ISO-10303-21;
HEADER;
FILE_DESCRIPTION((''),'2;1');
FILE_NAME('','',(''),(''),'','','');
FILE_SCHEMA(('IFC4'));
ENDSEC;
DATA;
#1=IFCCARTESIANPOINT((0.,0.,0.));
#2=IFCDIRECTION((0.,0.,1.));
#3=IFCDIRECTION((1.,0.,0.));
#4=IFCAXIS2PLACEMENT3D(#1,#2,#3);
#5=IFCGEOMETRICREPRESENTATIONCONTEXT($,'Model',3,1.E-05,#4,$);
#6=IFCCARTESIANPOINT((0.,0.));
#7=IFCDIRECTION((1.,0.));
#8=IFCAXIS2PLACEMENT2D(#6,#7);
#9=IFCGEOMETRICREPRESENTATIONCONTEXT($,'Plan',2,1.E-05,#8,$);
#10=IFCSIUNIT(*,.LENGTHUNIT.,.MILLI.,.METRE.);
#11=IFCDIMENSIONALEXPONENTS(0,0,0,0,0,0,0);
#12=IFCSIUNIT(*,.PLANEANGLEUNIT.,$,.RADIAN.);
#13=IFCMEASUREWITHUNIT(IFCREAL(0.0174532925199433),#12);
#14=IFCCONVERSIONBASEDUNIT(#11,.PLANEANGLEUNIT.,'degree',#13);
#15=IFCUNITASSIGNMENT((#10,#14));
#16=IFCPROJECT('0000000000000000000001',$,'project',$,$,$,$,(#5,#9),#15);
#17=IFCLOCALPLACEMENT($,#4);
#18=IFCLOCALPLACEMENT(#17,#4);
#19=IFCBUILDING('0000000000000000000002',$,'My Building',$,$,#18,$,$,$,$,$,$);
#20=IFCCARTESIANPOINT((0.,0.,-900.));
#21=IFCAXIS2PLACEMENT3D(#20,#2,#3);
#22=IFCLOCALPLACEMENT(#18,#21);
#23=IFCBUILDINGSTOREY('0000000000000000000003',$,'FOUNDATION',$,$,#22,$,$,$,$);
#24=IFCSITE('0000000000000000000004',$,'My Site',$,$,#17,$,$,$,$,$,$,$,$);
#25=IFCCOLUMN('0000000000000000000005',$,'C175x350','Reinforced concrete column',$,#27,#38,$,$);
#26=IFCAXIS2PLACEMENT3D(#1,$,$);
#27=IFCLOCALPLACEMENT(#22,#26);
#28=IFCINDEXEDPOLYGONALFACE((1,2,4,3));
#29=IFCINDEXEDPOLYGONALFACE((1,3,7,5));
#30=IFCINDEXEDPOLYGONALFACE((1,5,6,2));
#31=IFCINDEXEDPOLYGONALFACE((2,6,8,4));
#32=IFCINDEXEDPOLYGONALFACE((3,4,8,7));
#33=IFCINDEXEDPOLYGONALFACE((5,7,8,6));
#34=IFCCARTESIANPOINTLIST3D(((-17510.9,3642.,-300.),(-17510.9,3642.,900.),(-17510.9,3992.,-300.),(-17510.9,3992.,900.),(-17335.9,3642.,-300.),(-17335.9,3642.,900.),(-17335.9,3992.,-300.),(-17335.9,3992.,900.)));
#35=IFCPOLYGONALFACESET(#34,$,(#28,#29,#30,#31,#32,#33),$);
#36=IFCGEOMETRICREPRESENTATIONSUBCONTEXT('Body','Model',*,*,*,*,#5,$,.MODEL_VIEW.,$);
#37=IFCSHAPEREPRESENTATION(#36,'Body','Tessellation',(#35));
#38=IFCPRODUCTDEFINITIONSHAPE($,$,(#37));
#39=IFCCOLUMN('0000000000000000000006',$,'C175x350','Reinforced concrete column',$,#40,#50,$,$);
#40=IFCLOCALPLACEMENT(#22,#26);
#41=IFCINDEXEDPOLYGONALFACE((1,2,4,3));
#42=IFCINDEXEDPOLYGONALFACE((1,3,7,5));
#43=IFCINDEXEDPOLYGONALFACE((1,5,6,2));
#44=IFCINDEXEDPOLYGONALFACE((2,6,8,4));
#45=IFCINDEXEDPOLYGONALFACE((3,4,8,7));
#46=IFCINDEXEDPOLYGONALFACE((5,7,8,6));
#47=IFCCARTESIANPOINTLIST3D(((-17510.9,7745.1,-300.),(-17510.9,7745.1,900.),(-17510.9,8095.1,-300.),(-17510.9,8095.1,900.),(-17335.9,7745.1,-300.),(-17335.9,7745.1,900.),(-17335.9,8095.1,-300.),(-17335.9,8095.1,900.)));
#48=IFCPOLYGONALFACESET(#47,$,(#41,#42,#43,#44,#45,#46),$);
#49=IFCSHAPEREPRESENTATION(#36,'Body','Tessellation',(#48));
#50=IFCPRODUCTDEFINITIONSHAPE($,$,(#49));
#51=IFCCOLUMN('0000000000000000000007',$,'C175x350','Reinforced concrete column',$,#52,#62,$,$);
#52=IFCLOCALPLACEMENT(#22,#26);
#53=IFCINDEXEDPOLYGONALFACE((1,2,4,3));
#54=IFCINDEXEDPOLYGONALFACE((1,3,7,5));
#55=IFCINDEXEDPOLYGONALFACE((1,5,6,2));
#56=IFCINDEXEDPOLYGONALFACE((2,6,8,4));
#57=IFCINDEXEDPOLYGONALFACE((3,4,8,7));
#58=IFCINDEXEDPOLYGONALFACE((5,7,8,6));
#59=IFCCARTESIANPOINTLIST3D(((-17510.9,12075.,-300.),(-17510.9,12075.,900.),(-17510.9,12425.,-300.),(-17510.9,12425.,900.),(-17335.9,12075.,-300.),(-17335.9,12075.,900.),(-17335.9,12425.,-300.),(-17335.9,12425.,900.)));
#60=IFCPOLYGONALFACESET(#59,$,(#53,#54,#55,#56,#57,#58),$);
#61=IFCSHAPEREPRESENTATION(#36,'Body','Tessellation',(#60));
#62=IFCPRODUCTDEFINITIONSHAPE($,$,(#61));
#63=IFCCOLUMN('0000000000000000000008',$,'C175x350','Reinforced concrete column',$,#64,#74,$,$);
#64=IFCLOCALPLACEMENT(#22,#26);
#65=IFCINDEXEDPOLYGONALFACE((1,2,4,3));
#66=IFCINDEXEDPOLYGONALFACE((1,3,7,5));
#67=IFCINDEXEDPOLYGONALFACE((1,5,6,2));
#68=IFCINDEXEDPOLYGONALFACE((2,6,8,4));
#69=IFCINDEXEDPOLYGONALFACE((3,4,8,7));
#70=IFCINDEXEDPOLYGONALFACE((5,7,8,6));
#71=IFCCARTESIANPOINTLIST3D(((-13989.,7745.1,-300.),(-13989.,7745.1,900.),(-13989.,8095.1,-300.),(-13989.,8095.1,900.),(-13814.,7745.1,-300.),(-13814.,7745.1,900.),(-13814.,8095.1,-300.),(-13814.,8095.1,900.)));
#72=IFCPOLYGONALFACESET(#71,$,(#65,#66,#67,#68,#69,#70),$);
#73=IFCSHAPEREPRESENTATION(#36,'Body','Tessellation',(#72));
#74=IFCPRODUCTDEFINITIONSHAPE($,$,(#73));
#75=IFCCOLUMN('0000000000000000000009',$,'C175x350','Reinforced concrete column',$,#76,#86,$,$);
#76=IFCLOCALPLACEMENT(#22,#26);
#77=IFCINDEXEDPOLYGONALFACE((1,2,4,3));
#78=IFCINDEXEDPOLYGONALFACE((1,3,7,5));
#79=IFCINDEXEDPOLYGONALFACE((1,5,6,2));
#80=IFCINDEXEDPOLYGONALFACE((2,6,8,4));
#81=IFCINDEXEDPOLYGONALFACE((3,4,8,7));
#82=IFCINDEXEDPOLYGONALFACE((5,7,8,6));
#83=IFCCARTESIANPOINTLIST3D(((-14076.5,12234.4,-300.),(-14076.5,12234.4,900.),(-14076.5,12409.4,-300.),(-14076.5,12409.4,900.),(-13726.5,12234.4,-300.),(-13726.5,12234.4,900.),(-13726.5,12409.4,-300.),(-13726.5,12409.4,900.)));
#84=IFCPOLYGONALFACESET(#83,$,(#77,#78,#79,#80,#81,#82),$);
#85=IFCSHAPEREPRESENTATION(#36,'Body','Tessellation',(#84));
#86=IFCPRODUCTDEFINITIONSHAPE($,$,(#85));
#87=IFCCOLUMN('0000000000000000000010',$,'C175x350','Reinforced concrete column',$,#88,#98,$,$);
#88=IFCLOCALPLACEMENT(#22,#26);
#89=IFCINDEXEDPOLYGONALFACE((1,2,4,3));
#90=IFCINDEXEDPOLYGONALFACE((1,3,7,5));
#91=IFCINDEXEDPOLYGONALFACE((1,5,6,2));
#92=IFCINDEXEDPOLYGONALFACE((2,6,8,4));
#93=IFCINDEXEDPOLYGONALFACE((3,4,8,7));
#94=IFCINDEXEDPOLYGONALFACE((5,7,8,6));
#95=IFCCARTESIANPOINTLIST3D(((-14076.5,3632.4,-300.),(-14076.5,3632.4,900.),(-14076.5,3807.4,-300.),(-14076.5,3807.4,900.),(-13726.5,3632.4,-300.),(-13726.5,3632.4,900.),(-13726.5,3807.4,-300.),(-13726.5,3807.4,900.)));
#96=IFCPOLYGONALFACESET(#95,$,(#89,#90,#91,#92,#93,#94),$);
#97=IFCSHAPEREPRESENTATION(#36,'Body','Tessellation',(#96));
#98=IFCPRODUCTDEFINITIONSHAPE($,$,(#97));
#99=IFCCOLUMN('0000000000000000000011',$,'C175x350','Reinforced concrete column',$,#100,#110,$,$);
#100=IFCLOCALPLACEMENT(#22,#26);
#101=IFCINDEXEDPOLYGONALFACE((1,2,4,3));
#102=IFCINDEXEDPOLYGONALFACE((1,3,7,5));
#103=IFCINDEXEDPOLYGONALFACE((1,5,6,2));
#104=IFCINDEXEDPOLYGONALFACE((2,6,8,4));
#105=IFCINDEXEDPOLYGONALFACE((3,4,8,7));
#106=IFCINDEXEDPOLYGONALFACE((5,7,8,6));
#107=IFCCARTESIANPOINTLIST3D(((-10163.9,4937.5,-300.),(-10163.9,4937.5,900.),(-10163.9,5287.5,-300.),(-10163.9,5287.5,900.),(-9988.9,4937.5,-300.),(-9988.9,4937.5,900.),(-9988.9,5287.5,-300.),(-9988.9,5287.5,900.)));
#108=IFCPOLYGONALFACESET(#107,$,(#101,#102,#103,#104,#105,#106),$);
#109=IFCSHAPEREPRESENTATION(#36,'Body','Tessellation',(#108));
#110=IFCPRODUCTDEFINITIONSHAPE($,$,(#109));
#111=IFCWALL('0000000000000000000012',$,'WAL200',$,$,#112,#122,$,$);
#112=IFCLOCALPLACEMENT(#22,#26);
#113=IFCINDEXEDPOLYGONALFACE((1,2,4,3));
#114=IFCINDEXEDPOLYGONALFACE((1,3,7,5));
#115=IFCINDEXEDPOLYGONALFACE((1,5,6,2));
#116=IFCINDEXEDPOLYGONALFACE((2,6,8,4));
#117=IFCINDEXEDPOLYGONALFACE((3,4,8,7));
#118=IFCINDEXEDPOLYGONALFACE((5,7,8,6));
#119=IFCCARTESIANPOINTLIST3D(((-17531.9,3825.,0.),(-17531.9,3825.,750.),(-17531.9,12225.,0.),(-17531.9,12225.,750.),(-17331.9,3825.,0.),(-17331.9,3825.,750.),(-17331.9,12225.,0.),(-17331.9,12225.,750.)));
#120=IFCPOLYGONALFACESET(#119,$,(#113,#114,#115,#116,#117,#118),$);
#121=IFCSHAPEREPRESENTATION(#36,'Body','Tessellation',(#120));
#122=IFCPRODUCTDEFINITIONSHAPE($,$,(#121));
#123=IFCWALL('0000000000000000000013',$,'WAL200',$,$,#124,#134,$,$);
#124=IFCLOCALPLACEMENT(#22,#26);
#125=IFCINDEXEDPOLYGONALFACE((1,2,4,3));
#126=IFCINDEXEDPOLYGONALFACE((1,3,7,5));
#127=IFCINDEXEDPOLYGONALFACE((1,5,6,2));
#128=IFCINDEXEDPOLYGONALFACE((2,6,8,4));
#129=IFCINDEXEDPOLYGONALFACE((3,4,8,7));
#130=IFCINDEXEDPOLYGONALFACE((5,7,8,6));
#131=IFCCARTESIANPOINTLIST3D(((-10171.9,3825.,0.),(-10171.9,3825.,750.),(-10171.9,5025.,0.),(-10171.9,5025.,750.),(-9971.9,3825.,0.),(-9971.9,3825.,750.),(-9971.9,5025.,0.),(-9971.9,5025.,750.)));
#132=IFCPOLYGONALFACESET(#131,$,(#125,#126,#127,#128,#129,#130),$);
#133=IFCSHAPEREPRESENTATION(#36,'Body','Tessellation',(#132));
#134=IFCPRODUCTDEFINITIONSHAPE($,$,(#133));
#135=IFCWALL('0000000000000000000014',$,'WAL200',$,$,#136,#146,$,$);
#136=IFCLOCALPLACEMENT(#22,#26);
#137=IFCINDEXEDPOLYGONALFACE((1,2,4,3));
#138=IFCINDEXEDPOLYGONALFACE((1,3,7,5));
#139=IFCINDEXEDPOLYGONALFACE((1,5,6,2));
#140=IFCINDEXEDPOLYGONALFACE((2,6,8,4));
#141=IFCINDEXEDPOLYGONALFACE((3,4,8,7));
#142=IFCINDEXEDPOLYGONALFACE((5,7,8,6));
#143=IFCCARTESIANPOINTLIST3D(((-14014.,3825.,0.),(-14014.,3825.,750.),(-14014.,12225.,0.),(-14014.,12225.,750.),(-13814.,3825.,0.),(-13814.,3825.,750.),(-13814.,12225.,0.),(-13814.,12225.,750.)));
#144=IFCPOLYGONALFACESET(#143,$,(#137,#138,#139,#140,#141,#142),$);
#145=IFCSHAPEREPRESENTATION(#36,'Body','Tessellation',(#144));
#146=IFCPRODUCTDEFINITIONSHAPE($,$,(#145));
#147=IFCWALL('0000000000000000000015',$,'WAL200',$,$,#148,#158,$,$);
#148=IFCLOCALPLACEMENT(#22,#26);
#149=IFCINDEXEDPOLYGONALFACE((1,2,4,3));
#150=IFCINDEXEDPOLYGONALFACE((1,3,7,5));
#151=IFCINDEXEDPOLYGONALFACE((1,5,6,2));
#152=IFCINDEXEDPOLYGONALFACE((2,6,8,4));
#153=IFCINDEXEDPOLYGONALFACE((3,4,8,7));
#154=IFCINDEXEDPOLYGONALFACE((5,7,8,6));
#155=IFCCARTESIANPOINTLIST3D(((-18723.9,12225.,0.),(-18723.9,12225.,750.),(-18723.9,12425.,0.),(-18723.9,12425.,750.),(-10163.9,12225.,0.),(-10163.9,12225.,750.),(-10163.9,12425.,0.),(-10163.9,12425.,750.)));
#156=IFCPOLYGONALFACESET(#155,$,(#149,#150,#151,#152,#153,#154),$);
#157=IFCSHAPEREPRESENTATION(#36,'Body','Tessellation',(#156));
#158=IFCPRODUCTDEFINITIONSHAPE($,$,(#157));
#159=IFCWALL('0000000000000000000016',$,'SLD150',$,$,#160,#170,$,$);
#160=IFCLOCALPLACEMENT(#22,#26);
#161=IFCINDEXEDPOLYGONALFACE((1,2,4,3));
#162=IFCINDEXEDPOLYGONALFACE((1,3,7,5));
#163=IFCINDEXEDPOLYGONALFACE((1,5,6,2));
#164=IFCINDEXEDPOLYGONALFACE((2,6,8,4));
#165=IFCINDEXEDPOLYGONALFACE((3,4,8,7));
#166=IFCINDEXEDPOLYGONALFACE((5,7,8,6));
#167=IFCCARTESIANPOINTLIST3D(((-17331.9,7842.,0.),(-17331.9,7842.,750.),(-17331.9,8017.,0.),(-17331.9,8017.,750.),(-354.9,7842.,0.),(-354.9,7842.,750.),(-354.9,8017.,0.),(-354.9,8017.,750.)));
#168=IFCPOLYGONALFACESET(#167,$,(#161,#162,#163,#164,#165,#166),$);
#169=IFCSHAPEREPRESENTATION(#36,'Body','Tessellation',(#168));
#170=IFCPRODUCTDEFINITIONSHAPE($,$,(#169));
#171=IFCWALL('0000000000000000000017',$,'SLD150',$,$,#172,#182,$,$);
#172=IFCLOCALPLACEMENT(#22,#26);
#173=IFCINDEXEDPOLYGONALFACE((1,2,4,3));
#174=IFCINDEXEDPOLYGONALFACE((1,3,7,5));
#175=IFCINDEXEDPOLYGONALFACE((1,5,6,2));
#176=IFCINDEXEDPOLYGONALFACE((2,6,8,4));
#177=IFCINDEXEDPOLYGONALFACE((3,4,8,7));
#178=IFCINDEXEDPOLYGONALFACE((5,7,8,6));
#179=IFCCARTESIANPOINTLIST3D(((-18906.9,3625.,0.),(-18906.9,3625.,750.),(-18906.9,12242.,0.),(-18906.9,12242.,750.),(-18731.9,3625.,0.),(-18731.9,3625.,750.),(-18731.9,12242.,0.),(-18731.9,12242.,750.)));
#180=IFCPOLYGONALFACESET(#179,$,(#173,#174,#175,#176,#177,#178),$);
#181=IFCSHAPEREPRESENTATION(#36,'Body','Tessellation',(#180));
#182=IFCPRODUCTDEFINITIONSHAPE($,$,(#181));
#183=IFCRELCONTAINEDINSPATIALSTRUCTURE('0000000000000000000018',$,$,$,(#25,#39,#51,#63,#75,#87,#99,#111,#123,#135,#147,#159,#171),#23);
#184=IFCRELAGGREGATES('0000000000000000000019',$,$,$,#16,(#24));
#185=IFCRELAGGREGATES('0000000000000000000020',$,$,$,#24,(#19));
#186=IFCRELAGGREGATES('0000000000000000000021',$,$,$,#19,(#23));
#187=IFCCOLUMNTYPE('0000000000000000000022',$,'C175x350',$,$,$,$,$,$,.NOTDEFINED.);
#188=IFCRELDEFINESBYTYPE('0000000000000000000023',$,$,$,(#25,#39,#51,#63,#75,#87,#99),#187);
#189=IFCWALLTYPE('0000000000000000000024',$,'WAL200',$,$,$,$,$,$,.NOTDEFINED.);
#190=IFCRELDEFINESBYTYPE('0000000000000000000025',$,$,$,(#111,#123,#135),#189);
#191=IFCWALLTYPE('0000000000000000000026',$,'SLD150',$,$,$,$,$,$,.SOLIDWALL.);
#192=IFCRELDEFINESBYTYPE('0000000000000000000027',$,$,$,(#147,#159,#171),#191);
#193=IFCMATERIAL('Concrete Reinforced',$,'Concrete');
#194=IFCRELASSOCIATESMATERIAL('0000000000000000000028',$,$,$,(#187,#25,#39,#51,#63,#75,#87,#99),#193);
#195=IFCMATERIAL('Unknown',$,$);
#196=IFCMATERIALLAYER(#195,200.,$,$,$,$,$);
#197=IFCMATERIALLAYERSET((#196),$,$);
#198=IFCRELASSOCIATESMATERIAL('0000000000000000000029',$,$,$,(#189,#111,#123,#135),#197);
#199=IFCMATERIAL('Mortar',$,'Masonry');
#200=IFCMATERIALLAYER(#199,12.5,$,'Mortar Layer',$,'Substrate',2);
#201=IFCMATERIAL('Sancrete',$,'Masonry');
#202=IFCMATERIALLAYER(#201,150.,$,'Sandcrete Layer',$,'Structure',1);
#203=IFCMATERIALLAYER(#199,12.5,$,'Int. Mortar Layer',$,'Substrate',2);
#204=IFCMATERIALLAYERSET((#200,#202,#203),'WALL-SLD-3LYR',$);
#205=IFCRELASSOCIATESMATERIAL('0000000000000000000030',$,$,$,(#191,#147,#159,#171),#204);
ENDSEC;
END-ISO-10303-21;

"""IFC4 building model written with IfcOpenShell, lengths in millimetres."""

from ifc_helpers import new_model, entity, si_unit, converted_unit, frame, origin_with_axes, origin_2d_with_axis, place, context, subcontext, project, spatial, indexed_curve, rectangle, outline, extrude, material, layer, layer_set, layer_usage, material_profile, profile_set, profile_usage, type_object, element, save


model = new_model("IFC4")

# Units and contexts
model_context = context("Model", 3, precision=1e-05, world=origin_with_axes())
plan_context = context("Plan", 2, precision=1e-05, world=origin_2d_with_axis())
body_context = subcontext(model_context, "Body", "Model", "MODEL_VIEW")
ifc_project = project(units=[si_unit("LENGTHUNIT", "METRE", prefix="MILLI"), converted_unit("PLANEANGLEUNIT", "degree", entity("IfcReal", 0.0174532925199433), si_unit("PLANEANGLEUNIT", "RADIAN"), dimensions=[0, 0, 0, 0, 0, 0, 0])], contexts=[model_context, plan_context])

# Site, building, storey
site_placement = place(None, origin_with_axes())
site = spatial("IfcSite", under=ifc_project, at=site_placement, Name="My Site")
building_placement = place(site_placement, origin_with_axes())
building = spatial("IfcBuilding", under=site, at=building_placement, Name="My Building")
storey_placement = place(building_placement, frame((0.0, 0.0, -900.0), z_axis=(0.0, 0.0, 1.0), x_axis=(1.0, 0.0, 0.0)))
storey = spatial("IfcBuildingStorey", under=building, at=storey_placement, Name="FOUNDATION")

# Shared definitions
ifc_material_1 = material(Name="Concrete Reinforced", Category="Concrete")

# Columns
ifc_material_profile = material_profile(ifc_material_1, rectangle(XDim=175.0, YDim=350.0), Name="R. C. Layer", Category="Structure", Priority=1)
ifc_profile_set = profile_set([ifc_material_profile], Name="COL_1LYR")
column_type = type_object("IfcColumnType", Name="C175x350", PredefinedType="NOTDEFINED", material=ifc_profile_set)
ifc_profile_usage_1 = profile_usage(ifc_profile_set, cardinal=5)
column_1_placement = place(storey_placement, frame((-17423.4, 3817.0, -300.0), z_axis=(0.0, 0.0, 1.0), x_axis=(1.0, 0.0, 0.0)))
element("IfcColumn", 1, at=column_1_placement, inside=storey, type_object=column_type, material=ifc_profile_usage_1, Name="C175x350", Description="Reinforced concrete column", context=body_context, shape_type="SweptSolid", body=[
    extrude(rectangle(XDim=175.0, YDim=350.0), origin_with_axes(), (0.0, 0.0, 1.0), 1200.0),
])
ifc_profile_usage_2 = profile_usage(ifc_profile_set, cardinal=5)
column_2_placement = place(storey_placement, frame((-17423.4, 7920.1, -300.0), z_axis=(0.0, 0.0, 1.0), x_axis=(1.0, 0.0, 0.0)))
element("IfcColumn", 2, at=column_2_placement, inside=storey, type_object=column_type, material=ifc_profile_usage_2, Name="C175x350", Description="Reinforced concrete column", context=body_context, shape_type="SweptSolid", body=[
    extrude(rectangle(XDim=175.0, YDim=350.0), origin_with_axes(), (0.0, 0.0, 1.0), 1200.0),
])
ifc_profile_usage_3 = profile_usage(ifc_profile_set, cardinal=5)
column_3_placement = place(storey_placement, frame((-17423.4, 12250.0, -300.0), z_axis=(0.0, 0.0, 1.0), x_axis=(1.0, 0.0, 0.0)))
element("IfcColumn", 3, at=column_3_placement, inside=storey, type_object=column_type, material=ifc_profile_usage_3, Name="C175x350", Description="Reinforced concrete column", context=body_context, shape_type="SweptSolid", body=[
    extrude(rectangle(XDim=175.0, YDim=350.0), origin_with_axes(), (0.0, 0.0, 1.0), 1200.0),
])
ifc_profile_usage_4 = profile_usage(ifc_profile_set, cardinal=5)
column_4_placement = place(storey_placement, frame((-13901.5, 7920.1, -300.0), z_axis=(0.0, 0.0, 1.0), x_axis=(1.0, 0.0, 0.0)))
element("IfcColumn", 4, at=column_4_placement, inside=storey, type_object=column_type, material=ifc_profile_usage_4, Name="C175x350", Description="Reinforced concrete column", context=body_context, shape_type="SweptSolid", body=[
    extrude(rectangle(XDim=175.0, YDim=350.0), origin_with_axes(), (0.0, 0.0, 1.0), 1200.0),
])
ifc_profile_usage_5 = profile_usage(ifc_profile_set, cardinal=5)
column_5_placement = place(storey_placement, frame((-13901.5, 12321.9, -300.0), z_axis=(0.0, 0.0, 1.0), x_axis=(0.0, -1.0, 0.0)))
element("IfcColumn", 5, at=column_5_placement, inside=storey, type_object=column_type, material=ifc_profile_usage_5, Name="C175x350", Description="Reinforced concrete column", context=body_context, shape_type="SweptSolid", body=[
    extrude(rectangle(XDim=175.0, YDim=350.0), origin_with_axes(), (0.0, 0.0, 1.0), 1200.0),
])
ifc_profile_usage_6 = profile_usage(ifc_profile_set, cardinal=5)
column_6_placement = place(storey_placement, frame((-13901.5, 3719.9, -300.0), z_axis=(0.0, 0.0, 1.0), x_axis=(0.0, -1.0, 0.0)))
element("IfcColumn", 6, at=column_6_placement, inside=storey, type_object=column_type, material=ifc_profile_usage_6, Name="C175x350", Description="Reinforced concrete column", context=body_context, shape_type="SweptSolid", body=[
    extrude(rectangle(XDim=175.0, YDim=350.0), origin_with_axes(), (0.0, 0.0, 1.0), 1200.0),
])
ifc_profile_usage_7 = profile_usage(ifc_profile_set, cardinal=5)
column_7_placement = place(storey_placement, frame((-10076.4, 5112.5, -300.0), z_axis=(0.0, 0.0, 1.0), x_axis=(1.0, 0.0, 0.0)))
element("IfcColumn", 7, at=column_7_placement, inside=storey, type_object=column_type, material=ifc_profile_usage_7, Name="C175x350", Description="Reinforced concrete column", context=body_context, shape_type="SweptSolid", body=[
    extrude(rectangle(XDim=175.0, YDim=350.0), origin_with_axes(), (0.0, 0.0, 1.0), 1200.0),
])

# Walls
ifc_material_2 = material(Name="Unknown")
ifc_layer_1 = layer(ifc_material_2, 200.0)
ifc_layer_set_1 = layer_set([ifc_layer_1])
ifc_layer_usage_1 = layer_usage(ifc_layer_set_1, "AXIS2", "POSITIVE", 0.0)
wall_type_1 = type_object("IfcWallType", Name="WAL200", PredefinedType="NOTDEFINED", material=ifc_layer_set_1)
wall_1_placement = place(storey_placement, frame((-17331.9, 3825.0, 0.0), z_axis=(0.0, 0.0, 1.0), x_axis=(0.0, 1.0, 0.0)))
element("IfcWall", 8, at=wall_1_placement, inside=storey, type_object=wall_type_1, material=ifc_layer_usage_1, Name="WAL200", context=body_context, shape_type="SweptSolid", body=[
    extrude(outline(indexed_curve([(0.0, 0.0), (0.0, 200.0), (8400.0, 200.0), (8400.0, 0.0), (0.0, 0.0)], self_intersect=False)), origin_with_axes(), (0.0, 0.0, 1.0), 750.0),
])
ifc_layer_usage_2 = layer_usage(ifc_layer_set_1, "AXIS2", "POSITIVE", 0.0)
wall_2_placement = place(storey_placement, frame((-10171.9, 5025.0, 0.0), z_axis=(0.0, 0.0, 1.0), x_axis=(-0.000001, -1.0, 0.0)))
element("IfcWall", 9, at=wall_2_placement, inside=storey, type_object=wall_type_1, material=ifc_layer_usage_2, Name="WAL200", context=body_context, shape_type="SweptSolid", body=[
    extrude(outline(indexed_curve([(0.0, 0.0), (0.0, 200.0), (1200.0, 200.0), (1200.0, 0.0), (0.0, 0.0)], self_intersect=False)), origin_with_axes(), (0.0, 0.0, 1.0), 750.0),
])
ifc_layer_usage_3 = layer_usage(ifc_layer_set_1, "AXIS2", "POSITIVE", 0.0)
wall_3_placement = place(storey_placement, frame((-13814.0, 3825.0, 0.0), z_axis=(0.0, 0.0, 1.0), x_axis=(0.0, 1.0, 0.0)))
element("IfcWall", 10, at=wall_3_placement, inside=storey, type_object=wall_type_1, material=ifc_layer_usage_3, Name="WAL200", context=body_context, shape_type="SweptSolid", body=[
    extrude(outline(indexed_curve([(0.0, 0.0), (0.0, 200.0), (8400.0, 200.0), (8400.0, 0.0), (0.0, 0.0)], self_intersect=False)), origin_with_axes(), (0.0, 0.0, 1.0), 750.0),
])
ifc_material_3 = material(Name="Mortar", Category="Masonry")
ifc_layer_2 = layer(ifc_material_3, 12.5, Name="Mortar Layer", Category="Substrate", Priority=2)
ifc_material_4 = material(Name="Sancrete", Category="Masonry")
ifc_layer_3 = layer(ifc_material_4, 150.0, Name="Sandcrete Layer", Category="Structure", Priority=1)
ifc_layer_4 = layer(ifc_material_3, 12.5, Name="Int. Mortar Layer", Category="Substrate", Priority=2)
ifc_layer_set_2 = layer_set([ifc_layer_2, ifc_layer_3, ifc_layer_4], Name="WALL-SLD-3LYR")
ifc_layer_usage_4 = layer_usage(ifc_layer_set_2, "AXIS2", "POSITIVE", 0.0)
wall_type_2 = type_object("IfcWallType", Name="SLD150", PredefinedType="SOLIDWALL", material=ifc_layer_set_2)
wall_4_placement = place(storey_placement, frame((-10163.9, 12425.0, 0.0), z_axis=(0.0, 0.0, 1.0), x_axis=(-1.0, 0.0, 0.0)))
element("IfcWall", 11, at=wall_4_placement, inside=storey, type_object=wall_type_2, material=ifc_layer_usage_4, Name="WAL200", context=body_context, shape_type="SweptSolid", body=[
    extrude(outline(indexed_curve([(0.0, 0.0), (0.0, 200.0), (8560.0, 200.0), (8560.0, 0.0), (0.0, 0.0)], self_intersect=False)), origin_with_axes(), (0.0, 0.0, 1.0), 750.0),
])
ifc_layer_usage_5 = layer_usage(ifc_layer_set_2, "AXIS2", "POSITIVE", 0.0)
wall_5_placement = place(storey_placement, frame((-17331.9, 7842.0, 0.0), z_axis=(0.0, 0.0, 1.0), x_axis=(1.0, 0.0, 0.0)))
element("IfcWall", 12, at=wall_5_placement, inside=storey, type_object=wall_type_2, material=ifc_layer_usage_5, Name="SLD150", context=body_context, shape_type="SweptSolid", body=[
    extrude(outline(indexed_curve([(0.0, 0.0), (0.0, 175.0), (16977.0, 175.0), (16977.0, 0.0), (0.0, 0.0)], self_intersect=False)), origin_with_axes(), (0.0, 0.0, 1.0), 750.0),
])
ifc_layer_usage_6 = layer_usage(ifc_layer_set_2, "AXIS2", "POSITIVE", 0.0)
wall_6_placement = place(storey_placement, frame((-18731.9, 3625.0, 0.0), z_axis=(0.0, 0.0, 1.0), x_axis=(0.0, 1.0, 0.0)))
element("IfcWall", 13, at=wall_6_placement, inside=storey, type_object=wall_type_2, material=ifc_layer_usage_6, Name="SLD150", context=body_context, shape_type="SweptSolid", body=[
    extrude(outline(indexed_curve([(0.0, 0.0), (0.0, 175.0), (8617.0, 175.0), (8617.0, 0.0), (0.0, 0.0)], self_intersect=False)), origin_with_axes(), (0.0, 0.0, 1.0), 750.0),
])

save(model, "model.ifc")
